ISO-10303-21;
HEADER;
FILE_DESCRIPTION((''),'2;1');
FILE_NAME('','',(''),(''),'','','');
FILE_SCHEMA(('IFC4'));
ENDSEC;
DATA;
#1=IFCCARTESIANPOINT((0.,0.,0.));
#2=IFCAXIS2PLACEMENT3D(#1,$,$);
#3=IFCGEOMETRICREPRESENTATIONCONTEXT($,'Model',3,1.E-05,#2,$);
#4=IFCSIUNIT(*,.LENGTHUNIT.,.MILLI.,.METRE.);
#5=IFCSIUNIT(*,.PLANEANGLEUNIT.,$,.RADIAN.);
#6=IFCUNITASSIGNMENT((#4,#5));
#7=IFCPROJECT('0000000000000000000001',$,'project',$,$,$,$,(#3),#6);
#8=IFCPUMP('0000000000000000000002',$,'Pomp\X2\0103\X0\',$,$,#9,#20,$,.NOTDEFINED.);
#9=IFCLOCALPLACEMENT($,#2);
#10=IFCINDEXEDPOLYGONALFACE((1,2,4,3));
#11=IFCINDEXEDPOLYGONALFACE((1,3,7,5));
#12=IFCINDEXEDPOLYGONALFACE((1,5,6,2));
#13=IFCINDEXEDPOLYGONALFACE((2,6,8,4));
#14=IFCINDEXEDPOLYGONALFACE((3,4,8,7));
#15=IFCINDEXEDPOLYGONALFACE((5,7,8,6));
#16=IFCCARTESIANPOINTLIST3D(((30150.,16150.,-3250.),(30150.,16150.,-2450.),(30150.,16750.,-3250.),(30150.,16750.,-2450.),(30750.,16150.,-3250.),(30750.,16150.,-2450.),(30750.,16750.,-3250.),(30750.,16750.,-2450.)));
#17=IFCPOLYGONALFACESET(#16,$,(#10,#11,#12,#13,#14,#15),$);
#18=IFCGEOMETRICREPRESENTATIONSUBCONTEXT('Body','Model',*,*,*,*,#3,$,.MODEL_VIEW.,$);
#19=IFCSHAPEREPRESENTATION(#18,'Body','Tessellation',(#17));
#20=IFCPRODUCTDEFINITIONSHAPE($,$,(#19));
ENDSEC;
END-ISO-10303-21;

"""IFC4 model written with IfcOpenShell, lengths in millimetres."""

from ifc_helpers import new_model, si_unit, frame, frame_2d, origin, place, context, subcontext, project, rectangle, extrude, element, save


model = new_model("IFC4")

# Units and contexts
model_context = context("Model", 3, precision=1e-05, world=origin())
body_context = subcontext(model_context, "Body", "Model", "MODEL_VIEW")
ifc_project = project(units=[si_unit("LENGTHUNIT", "METRE", prefix="MILLI"), si_unit("PLANEANGLEUNIT", "RADIAN")], contexts=[model_context])

# Pump
pump_placement = place(None, frame((30150.0, 16150.0, -3250.0)))
element("IfcPump", 1, at=pump_placement, Name="Pompă", PredefinedType="NOTDEFINED", context=body_context, shape_type="SweptSolid", body=[
    extrude(rectangle(XDim=600.0, YDim=600.0, at=frame_2d((300.0, 300.0))), origin(), (0.0, 0.0, 1.0), 800.0),
])

save(model, "model.ifc")
